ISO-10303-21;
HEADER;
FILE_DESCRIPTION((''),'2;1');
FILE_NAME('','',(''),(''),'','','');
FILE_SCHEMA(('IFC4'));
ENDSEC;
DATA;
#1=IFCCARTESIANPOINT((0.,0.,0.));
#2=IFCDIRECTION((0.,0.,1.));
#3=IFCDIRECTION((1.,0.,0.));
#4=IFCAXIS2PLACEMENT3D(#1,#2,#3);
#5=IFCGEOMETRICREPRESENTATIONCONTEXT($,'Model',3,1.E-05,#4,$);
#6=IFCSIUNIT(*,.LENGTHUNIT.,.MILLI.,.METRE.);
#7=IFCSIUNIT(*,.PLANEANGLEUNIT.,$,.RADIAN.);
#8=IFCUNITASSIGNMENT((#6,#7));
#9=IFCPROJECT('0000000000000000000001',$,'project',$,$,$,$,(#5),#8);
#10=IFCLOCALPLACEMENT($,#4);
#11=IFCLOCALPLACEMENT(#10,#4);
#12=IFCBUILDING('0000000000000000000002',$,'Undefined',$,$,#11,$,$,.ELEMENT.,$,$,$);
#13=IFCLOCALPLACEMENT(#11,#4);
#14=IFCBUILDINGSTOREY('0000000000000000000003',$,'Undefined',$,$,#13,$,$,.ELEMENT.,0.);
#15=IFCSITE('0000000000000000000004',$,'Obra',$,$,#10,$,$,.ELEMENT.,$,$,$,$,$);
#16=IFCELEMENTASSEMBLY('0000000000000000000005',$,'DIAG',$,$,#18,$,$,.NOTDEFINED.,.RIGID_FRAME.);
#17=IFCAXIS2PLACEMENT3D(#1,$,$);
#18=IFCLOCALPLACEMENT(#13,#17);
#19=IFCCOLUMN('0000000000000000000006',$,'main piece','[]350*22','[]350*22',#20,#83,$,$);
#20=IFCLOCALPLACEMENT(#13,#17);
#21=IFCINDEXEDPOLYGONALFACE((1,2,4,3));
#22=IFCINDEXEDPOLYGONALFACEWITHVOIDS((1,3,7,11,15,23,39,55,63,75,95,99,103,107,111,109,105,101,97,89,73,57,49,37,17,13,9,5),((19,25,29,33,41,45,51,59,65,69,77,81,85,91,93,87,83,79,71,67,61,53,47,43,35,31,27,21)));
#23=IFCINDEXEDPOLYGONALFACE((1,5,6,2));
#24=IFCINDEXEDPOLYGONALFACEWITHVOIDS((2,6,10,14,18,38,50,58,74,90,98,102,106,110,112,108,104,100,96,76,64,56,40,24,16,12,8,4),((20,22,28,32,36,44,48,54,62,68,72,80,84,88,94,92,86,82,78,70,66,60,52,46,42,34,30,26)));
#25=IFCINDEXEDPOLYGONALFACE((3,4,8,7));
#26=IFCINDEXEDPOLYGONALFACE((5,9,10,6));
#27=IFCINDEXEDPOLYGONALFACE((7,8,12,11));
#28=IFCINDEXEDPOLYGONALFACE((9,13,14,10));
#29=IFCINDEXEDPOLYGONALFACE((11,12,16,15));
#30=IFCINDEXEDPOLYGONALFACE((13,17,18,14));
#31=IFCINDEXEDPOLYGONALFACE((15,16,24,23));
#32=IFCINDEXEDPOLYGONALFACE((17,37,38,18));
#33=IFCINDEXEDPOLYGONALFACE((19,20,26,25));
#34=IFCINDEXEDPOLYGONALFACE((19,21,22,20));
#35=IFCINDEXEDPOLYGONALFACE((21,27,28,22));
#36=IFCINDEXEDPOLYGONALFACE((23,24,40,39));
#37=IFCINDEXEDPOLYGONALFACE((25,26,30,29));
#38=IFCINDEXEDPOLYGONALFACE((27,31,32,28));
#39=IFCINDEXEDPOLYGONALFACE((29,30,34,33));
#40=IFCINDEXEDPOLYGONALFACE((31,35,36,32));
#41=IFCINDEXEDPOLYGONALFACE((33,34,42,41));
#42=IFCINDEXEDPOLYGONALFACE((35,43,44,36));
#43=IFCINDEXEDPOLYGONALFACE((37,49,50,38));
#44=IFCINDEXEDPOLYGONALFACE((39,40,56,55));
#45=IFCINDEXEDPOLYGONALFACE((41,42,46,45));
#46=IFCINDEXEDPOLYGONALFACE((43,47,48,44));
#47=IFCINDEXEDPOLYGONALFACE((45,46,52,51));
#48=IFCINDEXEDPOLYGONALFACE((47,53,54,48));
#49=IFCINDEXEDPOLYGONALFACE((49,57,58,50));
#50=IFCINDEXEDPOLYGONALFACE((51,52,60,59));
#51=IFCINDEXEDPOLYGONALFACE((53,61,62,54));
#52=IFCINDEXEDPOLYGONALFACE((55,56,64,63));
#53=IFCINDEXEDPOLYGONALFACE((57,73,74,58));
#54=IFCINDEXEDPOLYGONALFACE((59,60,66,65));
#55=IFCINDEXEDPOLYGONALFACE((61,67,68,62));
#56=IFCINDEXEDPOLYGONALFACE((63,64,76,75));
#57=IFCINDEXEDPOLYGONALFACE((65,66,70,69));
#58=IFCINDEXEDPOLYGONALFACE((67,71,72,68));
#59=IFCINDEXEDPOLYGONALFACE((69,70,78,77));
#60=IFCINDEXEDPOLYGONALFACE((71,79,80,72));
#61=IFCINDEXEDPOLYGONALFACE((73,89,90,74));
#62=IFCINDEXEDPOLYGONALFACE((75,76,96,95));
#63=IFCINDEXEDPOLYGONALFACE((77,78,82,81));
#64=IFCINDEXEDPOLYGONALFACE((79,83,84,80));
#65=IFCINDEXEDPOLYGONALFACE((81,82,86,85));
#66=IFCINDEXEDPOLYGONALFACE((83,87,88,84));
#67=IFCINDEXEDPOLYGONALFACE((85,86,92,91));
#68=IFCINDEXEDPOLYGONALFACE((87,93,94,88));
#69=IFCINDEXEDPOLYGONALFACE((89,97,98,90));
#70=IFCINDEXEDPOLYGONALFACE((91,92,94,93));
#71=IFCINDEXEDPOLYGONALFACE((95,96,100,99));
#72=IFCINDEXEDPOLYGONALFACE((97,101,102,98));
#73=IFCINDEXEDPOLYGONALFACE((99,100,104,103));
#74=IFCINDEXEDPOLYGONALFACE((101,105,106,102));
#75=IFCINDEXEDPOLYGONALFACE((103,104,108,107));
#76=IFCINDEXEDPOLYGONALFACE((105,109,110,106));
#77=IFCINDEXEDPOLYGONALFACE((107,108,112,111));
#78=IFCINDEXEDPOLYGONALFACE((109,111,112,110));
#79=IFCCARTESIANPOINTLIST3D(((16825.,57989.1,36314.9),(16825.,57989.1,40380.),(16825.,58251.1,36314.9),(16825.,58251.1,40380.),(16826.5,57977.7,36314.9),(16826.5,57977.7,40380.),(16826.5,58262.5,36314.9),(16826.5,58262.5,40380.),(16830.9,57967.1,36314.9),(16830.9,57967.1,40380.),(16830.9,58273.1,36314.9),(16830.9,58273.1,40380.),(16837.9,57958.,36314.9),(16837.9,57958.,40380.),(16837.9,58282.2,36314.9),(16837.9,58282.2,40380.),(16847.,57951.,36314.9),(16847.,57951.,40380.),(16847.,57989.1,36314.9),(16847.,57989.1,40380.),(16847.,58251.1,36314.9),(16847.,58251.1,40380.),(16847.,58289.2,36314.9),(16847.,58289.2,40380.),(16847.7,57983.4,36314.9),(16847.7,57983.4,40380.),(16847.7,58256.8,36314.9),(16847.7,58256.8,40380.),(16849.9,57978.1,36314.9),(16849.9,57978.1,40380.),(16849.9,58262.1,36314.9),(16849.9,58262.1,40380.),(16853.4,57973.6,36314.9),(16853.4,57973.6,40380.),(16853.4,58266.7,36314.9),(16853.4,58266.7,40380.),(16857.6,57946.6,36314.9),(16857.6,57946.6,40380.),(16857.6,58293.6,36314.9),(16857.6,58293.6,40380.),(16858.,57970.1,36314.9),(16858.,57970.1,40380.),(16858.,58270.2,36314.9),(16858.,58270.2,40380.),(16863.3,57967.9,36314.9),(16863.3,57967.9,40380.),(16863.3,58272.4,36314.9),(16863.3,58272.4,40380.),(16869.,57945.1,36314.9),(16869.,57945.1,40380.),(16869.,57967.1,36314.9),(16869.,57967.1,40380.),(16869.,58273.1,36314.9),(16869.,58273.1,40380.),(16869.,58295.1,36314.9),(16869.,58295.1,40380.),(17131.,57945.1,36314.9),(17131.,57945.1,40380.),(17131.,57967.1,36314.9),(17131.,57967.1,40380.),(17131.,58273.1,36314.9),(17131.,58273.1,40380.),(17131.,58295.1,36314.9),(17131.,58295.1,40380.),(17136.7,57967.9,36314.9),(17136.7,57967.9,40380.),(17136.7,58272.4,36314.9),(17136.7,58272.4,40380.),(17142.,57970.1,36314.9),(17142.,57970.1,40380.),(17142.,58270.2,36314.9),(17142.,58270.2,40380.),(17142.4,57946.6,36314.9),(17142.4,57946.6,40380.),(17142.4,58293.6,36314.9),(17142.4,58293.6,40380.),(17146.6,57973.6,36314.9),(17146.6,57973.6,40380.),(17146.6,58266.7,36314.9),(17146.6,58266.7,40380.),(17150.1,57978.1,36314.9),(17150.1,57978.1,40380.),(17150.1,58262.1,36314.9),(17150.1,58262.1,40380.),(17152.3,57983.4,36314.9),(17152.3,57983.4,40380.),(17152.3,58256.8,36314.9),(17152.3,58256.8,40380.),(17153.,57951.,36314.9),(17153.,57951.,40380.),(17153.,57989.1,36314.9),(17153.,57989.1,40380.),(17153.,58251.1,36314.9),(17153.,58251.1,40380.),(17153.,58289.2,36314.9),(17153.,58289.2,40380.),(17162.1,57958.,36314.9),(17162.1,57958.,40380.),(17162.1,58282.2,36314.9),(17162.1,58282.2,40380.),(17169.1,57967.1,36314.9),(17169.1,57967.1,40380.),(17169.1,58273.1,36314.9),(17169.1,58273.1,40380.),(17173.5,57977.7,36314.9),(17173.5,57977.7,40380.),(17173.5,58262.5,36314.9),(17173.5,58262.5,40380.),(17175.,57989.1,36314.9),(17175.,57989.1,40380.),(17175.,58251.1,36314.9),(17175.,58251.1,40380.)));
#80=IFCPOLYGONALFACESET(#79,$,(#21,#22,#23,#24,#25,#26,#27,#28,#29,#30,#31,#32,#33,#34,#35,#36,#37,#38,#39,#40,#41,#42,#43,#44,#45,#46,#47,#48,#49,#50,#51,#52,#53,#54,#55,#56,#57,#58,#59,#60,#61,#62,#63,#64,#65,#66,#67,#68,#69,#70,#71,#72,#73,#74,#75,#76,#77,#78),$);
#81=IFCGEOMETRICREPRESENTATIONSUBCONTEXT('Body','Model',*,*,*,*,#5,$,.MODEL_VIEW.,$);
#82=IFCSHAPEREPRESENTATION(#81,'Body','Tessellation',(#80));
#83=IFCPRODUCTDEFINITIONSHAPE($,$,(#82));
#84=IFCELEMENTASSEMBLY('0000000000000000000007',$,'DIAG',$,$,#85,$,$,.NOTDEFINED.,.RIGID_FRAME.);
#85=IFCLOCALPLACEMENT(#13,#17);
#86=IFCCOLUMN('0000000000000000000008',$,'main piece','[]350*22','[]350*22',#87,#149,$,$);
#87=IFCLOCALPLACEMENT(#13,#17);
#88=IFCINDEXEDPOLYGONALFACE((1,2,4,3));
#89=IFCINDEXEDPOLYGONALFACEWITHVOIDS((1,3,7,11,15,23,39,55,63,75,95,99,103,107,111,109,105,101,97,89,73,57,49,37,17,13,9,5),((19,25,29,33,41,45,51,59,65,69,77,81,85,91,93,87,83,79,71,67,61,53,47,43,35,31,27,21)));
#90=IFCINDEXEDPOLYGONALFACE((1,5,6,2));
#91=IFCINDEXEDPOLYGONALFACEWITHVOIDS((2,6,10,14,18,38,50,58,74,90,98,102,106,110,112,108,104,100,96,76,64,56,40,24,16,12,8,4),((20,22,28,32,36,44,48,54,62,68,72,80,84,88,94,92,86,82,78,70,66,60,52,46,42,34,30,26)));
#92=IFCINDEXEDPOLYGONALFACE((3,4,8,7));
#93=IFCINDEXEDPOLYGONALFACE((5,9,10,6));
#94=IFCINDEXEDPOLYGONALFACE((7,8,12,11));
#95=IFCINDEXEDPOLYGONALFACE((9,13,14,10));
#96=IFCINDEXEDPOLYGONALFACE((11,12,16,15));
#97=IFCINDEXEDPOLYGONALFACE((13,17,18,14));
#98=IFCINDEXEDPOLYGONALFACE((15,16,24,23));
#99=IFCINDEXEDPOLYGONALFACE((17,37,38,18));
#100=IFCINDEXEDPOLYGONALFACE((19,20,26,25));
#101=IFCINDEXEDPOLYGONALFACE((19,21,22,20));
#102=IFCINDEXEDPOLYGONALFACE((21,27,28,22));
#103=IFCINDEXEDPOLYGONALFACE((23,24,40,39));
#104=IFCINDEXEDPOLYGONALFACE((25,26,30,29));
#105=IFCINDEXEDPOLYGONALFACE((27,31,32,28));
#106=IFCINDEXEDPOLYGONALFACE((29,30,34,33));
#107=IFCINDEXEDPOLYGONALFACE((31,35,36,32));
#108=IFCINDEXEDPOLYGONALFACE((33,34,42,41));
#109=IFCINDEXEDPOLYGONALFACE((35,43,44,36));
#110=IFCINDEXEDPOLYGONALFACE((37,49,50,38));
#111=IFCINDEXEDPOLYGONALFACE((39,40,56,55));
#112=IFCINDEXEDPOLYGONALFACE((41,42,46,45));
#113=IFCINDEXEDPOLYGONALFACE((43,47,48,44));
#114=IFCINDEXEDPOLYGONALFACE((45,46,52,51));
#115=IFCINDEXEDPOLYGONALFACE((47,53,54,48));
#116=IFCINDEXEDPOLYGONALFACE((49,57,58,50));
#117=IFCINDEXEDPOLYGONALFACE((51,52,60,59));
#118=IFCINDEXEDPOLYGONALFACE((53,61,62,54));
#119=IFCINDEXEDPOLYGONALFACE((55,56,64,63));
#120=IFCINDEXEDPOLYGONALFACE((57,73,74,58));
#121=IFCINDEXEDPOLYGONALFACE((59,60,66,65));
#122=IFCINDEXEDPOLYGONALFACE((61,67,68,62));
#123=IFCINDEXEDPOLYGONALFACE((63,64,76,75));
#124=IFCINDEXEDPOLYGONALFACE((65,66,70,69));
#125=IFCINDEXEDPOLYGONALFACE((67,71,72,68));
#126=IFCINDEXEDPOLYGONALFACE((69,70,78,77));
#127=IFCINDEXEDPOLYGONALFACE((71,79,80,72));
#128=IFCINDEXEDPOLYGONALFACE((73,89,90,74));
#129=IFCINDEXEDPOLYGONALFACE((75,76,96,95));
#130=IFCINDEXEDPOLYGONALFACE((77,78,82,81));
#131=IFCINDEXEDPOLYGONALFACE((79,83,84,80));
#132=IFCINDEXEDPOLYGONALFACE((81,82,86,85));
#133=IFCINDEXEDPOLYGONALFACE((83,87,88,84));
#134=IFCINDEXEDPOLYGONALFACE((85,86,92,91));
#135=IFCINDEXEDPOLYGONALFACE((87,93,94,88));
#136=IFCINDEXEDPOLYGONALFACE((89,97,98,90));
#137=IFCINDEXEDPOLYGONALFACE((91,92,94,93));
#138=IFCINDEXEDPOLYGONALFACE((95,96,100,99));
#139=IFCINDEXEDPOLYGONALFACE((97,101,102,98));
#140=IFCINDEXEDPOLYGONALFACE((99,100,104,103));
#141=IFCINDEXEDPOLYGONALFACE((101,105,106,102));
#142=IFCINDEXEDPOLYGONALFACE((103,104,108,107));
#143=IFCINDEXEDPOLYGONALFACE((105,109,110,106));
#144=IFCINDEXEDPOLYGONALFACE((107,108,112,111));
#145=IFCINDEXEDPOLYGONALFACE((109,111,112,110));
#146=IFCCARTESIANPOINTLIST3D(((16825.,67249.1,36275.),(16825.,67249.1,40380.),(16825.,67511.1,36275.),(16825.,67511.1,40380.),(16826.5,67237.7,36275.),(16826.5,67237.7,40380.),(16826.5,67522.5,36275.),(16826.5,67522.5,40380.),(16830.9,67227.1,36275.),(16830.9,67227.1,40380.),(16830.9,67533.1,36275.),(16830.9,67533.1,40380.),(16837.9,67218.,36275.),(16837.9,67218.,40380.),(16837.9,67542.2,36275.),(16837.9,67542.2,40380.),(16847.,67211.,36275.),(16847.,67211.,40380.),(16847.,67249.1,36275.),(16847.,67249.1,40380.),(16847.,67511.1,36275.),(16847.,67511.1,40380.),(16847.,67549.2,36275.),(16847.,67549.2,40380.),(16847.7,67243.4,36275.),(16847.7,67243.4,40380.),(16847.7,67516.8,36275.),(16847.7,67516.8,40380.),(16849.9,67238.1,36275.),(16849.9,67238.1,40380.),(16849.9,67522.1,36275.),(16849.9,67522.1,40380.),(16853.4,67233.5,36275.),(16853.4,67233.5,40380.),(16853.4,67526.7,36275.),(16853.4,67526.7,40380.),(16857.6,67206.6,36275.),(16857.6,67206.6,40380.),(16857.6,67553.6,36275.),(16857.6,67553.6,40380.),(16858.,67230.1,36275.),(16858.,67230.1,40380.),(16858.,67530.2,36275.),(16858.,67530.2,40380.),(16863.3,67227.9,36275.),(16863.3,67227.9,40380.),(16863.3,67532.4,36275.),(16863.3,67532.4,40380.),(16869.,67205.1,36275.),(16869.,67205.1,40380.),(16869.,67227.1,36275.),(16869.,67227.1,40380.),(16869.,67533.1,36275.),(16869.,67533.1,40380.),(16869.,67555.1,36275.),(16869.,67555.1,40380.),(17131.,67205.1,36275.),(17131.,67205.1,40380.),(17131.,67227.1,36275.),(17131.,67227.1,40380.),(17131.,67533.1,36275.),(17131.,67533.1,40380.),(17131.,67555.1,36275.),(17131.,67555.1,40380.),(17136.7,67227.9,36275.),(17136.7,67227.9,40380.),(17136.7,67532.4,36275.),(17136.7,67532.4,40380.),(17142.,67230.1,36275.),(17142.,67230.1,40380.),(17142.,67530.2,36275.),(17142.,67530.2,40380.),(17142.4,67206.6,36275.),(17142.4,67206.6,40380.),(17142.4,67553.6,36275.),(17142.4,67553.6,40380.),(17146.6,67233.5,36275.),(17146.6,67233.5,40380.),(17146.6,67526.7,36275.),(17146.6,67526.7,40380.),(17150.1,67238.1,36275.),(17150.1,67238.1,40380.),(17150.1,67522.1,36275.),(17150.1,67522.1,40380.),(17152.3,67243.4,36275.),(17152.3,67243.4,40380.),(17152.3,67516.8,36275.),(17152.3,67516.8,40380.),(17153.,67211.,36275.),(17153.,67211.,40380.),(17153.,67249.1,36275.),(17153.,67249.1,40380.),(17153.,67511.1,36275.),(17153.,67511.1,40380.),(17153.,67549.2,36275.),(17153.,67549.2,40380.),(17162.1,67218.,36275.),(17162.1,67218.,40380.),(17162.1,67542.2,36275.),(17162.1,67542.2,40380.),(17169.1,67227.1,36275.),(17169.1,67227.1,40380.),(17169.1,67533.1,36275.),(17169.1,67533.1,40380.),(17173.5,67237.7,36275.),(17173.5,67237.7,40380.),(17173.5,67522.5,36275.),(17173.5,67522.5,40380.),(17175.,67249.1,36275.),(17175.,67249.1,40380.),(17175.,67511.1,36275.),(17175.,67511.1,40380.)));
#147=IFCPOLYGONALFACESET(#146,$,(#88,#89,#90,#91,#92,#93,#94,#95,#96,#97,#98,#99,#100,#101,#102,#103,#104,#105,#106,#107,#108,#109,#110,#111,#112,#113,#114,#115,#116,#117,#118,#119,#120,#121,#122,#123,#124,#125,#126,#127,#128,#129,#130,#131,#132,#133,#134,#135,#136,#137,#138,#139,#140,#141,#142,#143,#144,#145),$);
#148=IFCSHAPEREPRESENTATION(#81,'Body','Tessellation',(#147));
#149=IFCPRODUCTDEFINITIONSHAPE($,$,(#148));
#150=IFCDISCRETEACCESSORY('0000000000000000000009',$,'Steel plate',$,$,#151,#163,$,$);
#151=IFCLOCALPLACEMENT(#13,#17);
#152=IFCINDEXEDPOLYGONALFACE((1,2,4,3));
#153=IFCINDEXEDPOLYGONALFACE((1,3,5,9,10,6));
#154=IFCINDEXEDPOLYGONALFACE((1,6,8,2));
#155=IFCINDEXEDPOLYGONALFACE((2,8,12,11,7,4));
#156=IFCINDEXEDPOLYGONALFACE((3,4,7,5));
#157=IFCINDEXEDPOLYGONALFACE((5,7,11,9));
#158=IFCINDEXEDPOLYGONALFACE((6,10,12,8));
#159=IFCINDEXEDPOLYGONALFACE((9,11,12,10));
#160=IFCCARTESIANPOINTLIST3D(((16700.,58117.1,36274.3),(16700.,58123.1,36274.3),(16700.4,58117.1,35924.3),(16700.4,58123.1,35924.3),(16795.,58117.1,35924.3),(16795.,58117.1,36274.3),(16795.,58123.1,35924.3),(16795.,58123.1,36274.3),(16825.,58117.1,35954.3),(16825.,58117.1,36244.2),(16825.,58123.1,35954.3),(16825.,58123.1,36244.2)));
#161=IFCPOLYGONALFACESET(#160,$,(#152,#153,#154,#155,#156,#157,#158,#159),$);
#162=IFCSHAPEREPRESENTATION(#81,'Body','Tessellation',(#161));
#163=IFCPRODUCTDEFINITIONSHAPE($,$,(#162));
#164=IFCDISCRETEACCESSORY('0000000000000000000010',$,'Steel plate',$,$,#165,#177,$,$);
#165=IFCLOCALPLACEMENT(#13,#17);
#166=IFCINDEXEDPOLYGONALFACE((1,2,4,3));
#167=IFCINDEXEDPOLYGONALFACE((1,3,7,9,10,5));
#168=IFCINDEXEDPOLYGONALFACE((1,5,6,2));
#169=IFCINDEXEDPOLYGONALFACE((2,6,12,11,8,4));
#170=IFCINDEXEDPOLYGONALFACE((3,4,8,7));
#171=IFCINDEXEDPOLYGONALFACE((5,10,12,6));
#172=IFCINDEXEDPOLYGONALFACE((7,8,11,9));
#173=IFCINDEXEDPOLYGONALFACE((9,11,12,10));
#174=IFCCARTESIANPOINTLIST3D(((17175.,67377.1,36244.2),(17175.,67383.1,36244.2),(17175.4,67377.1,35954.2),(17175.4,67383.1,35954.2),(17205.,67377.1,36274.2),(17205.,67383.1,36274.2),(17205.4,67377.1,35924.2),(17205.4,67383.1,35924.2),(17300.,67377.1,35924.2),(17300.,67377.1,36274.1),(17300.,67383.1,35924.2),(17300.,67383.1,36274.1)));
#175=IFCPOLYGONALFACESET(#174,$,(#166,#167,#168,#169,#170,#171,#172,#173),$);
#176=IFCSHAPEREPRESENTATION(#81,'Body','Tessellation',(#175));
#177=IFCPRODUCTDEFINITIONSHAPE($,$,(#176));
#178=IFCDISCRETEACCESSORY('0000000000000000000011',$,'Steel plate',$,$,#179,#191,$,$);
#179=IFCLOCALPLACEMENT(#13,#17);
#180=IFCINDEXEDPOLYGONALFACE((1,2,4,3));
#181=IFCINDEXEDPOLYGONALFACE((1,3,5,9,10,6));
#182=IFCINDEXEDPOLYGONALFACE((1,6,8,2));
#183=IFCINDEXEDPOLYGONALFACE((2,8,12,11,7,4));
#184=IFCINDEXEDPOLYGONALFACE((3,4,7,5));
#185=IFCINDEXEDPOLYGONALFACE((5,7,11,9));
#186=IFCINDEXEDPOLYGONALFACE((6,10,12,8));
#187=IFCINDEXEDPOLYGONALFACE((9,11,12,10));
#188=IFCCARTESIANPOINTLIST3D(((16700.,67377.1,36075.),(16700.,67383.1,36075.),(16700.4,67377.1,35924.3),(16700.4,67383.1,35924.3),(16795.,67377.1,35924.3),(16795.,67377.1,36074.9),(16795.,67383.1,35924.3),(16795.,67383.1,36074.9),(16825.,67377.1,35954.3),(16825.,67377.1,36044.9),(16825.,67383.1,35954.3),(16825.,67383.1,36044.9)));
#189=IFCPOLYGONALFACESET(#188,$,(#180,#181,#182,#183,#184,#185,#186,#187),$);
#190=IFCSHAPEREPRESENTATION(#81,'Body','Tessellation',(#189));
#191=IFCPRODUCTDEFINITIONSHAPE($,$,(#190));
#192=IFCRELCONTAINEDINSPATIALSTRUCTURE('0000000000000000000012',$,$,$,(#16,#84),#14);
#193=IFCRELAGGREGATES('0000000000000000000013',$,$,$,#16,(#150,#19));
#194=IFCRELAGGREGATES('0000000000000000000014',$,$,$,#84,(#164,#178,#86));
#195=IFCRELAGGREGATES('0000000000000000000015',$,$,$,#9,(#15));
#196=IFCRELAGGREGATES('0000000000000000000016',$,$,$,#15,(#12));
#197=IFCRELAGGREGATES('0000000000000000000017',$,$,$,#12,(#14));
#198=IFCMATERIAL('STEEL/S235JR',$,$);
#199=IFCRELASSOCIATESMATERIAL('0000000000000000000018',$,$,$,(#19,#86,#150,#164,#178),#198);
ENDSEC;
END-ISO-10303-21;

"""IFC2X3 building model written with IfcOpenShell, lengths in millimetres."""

from ifc_helpers import new_model, si_unit, frame, origin_with_axes, origin_2d_with_axis, place, context, subcontext, project, spatial, polyline, hollow_rectangle, outline, extrude, material, element, aggregate, save


model = new_model("IFC2X3")

# Units and contexts
model_context = context("Model", 3, precision=1e-05, world=origin_with_axes())
body_context = subcontext(model_context, "Body", "Model", "MODEL_VIEW")
ifc_project = project(units=[si_unit("LENGTHUNIT", "METRE", prefix="MILLI"), si_unit("PLANEANGLEUNIT", "RADIAN")], contexts=[model_context])

# Site, building, storey
site_placement = place(None, origin_with_axes())
site = spatial("IfcSite", under=ifc_project, at=site_placement, Name="Obra", CompositionType="ELEMENT")
building_placement = place(site_placement, origin_with_axes())
building = spatial("IfcBuilding", under=site, at=building_placement, Name="Undefined", CompositionType="ELEMENT")
storey_placement = place(building_placement, origin_with_axes())
storey = spatial("IfcBuildingStorey", under=building, at=storey_placement, Name="Undefined", CompositionType="ELEMENT", Elevation=0.0)

# Element assemblies, columns
assembly_1_placement = place(storey_placement, origin_with_axes())
assembly_1 = element("IfcElementAssembly", 1, at=assembly_1_placement, inside=storey, Name="DIAG", AssemblyPlace="NOTDEFINED", PredefinedType="RIGID_FRAME")
ifc_material_1 = material(Name="STEEL/S235JR")
column_1_placement = place(assembly_1_placement, frame((17000.0, 58120.1, 36314.8), z_axis=(0.0, 0.0, 1.0), x_axis=(-1.0, 0.0, 0.0)))
column_1 = element("IfcColumn", 2, at=column_1_placement, material=ifc_material_1, Name="main piece", Description="[]350*22", ObjectType="[]350*22", context=body_context, shape_type="SweptSolid", body=[
    extrude(hollow_rectangle(XDim=350.0, YDim=350.0, WallThickness=22.0, InnerFilletRadius=22.0, OuterFilletRadius=44.0, at=origin_2d_with_axis()), frame((0.0, 0.0, 4065.2), z_axis=(0.0, 0.0, -1.0), x_axis=(0.0, 1.0, 0.0)), (0.0, 0.0, 1.0), 4065.2),
])
assembly_2_placement = place(storey_placement, origin_with_axes())
assembly_2 = element("IfcElementAssembly", 3, at=assembly_2_placement, inside=storey, Name="DIAG", AssemblyPlace="NOTDEFINED", PredefinedType="RIGID_FRAME")
column_2_placement = place(assembly_2_placement, frame((17000.0, 67380.1, 36275.0), z_axis=(0.0, 0.0, 1.0), x_axis=(-1.0, 0.0, 0.0)))
column_2 = element("IfcColumn", 4, at=column_2_placement, material=ifc_material_1, Name="main piece", Description="[]350*22", ObjectType="[]350*22", context=body_context, shape_type="SweptSolid", body=[
    extrude(hollow_rectangle(XDim=350.0, YDim=350.0, WallThickness=22.0, InnerFilletRadius=22.0, OuterFilletRadius=44.0, at=origin_2d_with_axis()), frame((0.0, 0.0, 4105.0), z_axis=(0.0, 0.0, -1.0), x_axis=(0.0, 1.0, 0.0)), (0.0, 0.0, 1.0), 4105.0),
])

# Discrete accessory
discrete_accessory_1_placement = place(assembly_1_placement, frame((16825.0, 58120.1, 35924.3), z_axis=(0.0, 1.0, 0.0), x_axis=(-1.0, 0.0, 0.0)))
discrete_accessory_1 = element("IfcDiscreteAccessory", 5, at=discrete_accessory_1_placement, material=ifc_material_1, Name="Steel plate", context=body_context, shape_type="SweptSolid", body=[
    extrude(outline(polyline([(0.0, 30.0), (30.0, 0.0), (124.6, 0.0), (125.0, 350.0), (30.0, 349.9), (0.0, 319.9), (0.0, 30.0)])), frame((0.0, 0.0, -3.0), z_axis=(0.0, 0.0, 1.0), x_axis=(1.0, 0.0, 0.0)), (0.0, 0.0, 1.0), 6.0),
])

# Discrete accessories
discrete_accessory_2_placement = place(assembly_2_placement, frame((17300.0, 67380.1, 35924.2), z_axis=(0.0, 1.0, 0.0), x_axis=(-1.0, 0.0, 0.0)))
discrete_accessory_2 = element("IfcDiscreteAccessory", 6, at=discrete_accessory_2_placement, material=ifc_material_1, Name="Steel plate", context=body_context, shape_type="SweptSolid", body=[
    extrude(outline(polyline([(0.0, 0.0), (94.6, 0.0), (124.6, 30.0), (125.0, 320.0), (95.0, 350.0), (0.0, 349.9), (0.0, 0.0)])), frame((0.0, 0.0, -3.0), z_axis=(0.0, 0.0, 1.0), x_axis=(1.0, 0.0, 0.0)), (0.0, 0.0, 1.0), 6.0),
])
discrete_accessory_3_placement = place(assembly_2_placement, frame((16825.0, 67380.1, 35924.3), z_axis=(0.0, 1.0, 0.0), x_axis=(-1.0, 0.0, 0.0)))
discrete_accessory_3 = element("IfcDiscreteAccessory", 7, at=discrete_accessory_3_placement, material=ifc_material_1, Name="Steel plate", context=body_context, shape_type="SweptSolid", body=[
    extrude(outline(polyline([(0.0, 30.0), (30.0, 0.0), (124.6, 0.0), (125.0, 150.7), (30.0, 150.6), (0.0, 120.5), (0.0, 30.0)])), frame((0.0, 0.0, -3.0), z_axis=(0.0, 0.0, 1.0), x_axis=(1.0, 0.0, 0.0)), (0.0, 0.0, 1.0), 6.0),
])

aggregate(assembly_1, [discrete_accessory_1, column_1])
aggregate(assembly_2, [discrete_accessory_2, discrete_accessory_3, column_2])

save(model, "model.ifc")
